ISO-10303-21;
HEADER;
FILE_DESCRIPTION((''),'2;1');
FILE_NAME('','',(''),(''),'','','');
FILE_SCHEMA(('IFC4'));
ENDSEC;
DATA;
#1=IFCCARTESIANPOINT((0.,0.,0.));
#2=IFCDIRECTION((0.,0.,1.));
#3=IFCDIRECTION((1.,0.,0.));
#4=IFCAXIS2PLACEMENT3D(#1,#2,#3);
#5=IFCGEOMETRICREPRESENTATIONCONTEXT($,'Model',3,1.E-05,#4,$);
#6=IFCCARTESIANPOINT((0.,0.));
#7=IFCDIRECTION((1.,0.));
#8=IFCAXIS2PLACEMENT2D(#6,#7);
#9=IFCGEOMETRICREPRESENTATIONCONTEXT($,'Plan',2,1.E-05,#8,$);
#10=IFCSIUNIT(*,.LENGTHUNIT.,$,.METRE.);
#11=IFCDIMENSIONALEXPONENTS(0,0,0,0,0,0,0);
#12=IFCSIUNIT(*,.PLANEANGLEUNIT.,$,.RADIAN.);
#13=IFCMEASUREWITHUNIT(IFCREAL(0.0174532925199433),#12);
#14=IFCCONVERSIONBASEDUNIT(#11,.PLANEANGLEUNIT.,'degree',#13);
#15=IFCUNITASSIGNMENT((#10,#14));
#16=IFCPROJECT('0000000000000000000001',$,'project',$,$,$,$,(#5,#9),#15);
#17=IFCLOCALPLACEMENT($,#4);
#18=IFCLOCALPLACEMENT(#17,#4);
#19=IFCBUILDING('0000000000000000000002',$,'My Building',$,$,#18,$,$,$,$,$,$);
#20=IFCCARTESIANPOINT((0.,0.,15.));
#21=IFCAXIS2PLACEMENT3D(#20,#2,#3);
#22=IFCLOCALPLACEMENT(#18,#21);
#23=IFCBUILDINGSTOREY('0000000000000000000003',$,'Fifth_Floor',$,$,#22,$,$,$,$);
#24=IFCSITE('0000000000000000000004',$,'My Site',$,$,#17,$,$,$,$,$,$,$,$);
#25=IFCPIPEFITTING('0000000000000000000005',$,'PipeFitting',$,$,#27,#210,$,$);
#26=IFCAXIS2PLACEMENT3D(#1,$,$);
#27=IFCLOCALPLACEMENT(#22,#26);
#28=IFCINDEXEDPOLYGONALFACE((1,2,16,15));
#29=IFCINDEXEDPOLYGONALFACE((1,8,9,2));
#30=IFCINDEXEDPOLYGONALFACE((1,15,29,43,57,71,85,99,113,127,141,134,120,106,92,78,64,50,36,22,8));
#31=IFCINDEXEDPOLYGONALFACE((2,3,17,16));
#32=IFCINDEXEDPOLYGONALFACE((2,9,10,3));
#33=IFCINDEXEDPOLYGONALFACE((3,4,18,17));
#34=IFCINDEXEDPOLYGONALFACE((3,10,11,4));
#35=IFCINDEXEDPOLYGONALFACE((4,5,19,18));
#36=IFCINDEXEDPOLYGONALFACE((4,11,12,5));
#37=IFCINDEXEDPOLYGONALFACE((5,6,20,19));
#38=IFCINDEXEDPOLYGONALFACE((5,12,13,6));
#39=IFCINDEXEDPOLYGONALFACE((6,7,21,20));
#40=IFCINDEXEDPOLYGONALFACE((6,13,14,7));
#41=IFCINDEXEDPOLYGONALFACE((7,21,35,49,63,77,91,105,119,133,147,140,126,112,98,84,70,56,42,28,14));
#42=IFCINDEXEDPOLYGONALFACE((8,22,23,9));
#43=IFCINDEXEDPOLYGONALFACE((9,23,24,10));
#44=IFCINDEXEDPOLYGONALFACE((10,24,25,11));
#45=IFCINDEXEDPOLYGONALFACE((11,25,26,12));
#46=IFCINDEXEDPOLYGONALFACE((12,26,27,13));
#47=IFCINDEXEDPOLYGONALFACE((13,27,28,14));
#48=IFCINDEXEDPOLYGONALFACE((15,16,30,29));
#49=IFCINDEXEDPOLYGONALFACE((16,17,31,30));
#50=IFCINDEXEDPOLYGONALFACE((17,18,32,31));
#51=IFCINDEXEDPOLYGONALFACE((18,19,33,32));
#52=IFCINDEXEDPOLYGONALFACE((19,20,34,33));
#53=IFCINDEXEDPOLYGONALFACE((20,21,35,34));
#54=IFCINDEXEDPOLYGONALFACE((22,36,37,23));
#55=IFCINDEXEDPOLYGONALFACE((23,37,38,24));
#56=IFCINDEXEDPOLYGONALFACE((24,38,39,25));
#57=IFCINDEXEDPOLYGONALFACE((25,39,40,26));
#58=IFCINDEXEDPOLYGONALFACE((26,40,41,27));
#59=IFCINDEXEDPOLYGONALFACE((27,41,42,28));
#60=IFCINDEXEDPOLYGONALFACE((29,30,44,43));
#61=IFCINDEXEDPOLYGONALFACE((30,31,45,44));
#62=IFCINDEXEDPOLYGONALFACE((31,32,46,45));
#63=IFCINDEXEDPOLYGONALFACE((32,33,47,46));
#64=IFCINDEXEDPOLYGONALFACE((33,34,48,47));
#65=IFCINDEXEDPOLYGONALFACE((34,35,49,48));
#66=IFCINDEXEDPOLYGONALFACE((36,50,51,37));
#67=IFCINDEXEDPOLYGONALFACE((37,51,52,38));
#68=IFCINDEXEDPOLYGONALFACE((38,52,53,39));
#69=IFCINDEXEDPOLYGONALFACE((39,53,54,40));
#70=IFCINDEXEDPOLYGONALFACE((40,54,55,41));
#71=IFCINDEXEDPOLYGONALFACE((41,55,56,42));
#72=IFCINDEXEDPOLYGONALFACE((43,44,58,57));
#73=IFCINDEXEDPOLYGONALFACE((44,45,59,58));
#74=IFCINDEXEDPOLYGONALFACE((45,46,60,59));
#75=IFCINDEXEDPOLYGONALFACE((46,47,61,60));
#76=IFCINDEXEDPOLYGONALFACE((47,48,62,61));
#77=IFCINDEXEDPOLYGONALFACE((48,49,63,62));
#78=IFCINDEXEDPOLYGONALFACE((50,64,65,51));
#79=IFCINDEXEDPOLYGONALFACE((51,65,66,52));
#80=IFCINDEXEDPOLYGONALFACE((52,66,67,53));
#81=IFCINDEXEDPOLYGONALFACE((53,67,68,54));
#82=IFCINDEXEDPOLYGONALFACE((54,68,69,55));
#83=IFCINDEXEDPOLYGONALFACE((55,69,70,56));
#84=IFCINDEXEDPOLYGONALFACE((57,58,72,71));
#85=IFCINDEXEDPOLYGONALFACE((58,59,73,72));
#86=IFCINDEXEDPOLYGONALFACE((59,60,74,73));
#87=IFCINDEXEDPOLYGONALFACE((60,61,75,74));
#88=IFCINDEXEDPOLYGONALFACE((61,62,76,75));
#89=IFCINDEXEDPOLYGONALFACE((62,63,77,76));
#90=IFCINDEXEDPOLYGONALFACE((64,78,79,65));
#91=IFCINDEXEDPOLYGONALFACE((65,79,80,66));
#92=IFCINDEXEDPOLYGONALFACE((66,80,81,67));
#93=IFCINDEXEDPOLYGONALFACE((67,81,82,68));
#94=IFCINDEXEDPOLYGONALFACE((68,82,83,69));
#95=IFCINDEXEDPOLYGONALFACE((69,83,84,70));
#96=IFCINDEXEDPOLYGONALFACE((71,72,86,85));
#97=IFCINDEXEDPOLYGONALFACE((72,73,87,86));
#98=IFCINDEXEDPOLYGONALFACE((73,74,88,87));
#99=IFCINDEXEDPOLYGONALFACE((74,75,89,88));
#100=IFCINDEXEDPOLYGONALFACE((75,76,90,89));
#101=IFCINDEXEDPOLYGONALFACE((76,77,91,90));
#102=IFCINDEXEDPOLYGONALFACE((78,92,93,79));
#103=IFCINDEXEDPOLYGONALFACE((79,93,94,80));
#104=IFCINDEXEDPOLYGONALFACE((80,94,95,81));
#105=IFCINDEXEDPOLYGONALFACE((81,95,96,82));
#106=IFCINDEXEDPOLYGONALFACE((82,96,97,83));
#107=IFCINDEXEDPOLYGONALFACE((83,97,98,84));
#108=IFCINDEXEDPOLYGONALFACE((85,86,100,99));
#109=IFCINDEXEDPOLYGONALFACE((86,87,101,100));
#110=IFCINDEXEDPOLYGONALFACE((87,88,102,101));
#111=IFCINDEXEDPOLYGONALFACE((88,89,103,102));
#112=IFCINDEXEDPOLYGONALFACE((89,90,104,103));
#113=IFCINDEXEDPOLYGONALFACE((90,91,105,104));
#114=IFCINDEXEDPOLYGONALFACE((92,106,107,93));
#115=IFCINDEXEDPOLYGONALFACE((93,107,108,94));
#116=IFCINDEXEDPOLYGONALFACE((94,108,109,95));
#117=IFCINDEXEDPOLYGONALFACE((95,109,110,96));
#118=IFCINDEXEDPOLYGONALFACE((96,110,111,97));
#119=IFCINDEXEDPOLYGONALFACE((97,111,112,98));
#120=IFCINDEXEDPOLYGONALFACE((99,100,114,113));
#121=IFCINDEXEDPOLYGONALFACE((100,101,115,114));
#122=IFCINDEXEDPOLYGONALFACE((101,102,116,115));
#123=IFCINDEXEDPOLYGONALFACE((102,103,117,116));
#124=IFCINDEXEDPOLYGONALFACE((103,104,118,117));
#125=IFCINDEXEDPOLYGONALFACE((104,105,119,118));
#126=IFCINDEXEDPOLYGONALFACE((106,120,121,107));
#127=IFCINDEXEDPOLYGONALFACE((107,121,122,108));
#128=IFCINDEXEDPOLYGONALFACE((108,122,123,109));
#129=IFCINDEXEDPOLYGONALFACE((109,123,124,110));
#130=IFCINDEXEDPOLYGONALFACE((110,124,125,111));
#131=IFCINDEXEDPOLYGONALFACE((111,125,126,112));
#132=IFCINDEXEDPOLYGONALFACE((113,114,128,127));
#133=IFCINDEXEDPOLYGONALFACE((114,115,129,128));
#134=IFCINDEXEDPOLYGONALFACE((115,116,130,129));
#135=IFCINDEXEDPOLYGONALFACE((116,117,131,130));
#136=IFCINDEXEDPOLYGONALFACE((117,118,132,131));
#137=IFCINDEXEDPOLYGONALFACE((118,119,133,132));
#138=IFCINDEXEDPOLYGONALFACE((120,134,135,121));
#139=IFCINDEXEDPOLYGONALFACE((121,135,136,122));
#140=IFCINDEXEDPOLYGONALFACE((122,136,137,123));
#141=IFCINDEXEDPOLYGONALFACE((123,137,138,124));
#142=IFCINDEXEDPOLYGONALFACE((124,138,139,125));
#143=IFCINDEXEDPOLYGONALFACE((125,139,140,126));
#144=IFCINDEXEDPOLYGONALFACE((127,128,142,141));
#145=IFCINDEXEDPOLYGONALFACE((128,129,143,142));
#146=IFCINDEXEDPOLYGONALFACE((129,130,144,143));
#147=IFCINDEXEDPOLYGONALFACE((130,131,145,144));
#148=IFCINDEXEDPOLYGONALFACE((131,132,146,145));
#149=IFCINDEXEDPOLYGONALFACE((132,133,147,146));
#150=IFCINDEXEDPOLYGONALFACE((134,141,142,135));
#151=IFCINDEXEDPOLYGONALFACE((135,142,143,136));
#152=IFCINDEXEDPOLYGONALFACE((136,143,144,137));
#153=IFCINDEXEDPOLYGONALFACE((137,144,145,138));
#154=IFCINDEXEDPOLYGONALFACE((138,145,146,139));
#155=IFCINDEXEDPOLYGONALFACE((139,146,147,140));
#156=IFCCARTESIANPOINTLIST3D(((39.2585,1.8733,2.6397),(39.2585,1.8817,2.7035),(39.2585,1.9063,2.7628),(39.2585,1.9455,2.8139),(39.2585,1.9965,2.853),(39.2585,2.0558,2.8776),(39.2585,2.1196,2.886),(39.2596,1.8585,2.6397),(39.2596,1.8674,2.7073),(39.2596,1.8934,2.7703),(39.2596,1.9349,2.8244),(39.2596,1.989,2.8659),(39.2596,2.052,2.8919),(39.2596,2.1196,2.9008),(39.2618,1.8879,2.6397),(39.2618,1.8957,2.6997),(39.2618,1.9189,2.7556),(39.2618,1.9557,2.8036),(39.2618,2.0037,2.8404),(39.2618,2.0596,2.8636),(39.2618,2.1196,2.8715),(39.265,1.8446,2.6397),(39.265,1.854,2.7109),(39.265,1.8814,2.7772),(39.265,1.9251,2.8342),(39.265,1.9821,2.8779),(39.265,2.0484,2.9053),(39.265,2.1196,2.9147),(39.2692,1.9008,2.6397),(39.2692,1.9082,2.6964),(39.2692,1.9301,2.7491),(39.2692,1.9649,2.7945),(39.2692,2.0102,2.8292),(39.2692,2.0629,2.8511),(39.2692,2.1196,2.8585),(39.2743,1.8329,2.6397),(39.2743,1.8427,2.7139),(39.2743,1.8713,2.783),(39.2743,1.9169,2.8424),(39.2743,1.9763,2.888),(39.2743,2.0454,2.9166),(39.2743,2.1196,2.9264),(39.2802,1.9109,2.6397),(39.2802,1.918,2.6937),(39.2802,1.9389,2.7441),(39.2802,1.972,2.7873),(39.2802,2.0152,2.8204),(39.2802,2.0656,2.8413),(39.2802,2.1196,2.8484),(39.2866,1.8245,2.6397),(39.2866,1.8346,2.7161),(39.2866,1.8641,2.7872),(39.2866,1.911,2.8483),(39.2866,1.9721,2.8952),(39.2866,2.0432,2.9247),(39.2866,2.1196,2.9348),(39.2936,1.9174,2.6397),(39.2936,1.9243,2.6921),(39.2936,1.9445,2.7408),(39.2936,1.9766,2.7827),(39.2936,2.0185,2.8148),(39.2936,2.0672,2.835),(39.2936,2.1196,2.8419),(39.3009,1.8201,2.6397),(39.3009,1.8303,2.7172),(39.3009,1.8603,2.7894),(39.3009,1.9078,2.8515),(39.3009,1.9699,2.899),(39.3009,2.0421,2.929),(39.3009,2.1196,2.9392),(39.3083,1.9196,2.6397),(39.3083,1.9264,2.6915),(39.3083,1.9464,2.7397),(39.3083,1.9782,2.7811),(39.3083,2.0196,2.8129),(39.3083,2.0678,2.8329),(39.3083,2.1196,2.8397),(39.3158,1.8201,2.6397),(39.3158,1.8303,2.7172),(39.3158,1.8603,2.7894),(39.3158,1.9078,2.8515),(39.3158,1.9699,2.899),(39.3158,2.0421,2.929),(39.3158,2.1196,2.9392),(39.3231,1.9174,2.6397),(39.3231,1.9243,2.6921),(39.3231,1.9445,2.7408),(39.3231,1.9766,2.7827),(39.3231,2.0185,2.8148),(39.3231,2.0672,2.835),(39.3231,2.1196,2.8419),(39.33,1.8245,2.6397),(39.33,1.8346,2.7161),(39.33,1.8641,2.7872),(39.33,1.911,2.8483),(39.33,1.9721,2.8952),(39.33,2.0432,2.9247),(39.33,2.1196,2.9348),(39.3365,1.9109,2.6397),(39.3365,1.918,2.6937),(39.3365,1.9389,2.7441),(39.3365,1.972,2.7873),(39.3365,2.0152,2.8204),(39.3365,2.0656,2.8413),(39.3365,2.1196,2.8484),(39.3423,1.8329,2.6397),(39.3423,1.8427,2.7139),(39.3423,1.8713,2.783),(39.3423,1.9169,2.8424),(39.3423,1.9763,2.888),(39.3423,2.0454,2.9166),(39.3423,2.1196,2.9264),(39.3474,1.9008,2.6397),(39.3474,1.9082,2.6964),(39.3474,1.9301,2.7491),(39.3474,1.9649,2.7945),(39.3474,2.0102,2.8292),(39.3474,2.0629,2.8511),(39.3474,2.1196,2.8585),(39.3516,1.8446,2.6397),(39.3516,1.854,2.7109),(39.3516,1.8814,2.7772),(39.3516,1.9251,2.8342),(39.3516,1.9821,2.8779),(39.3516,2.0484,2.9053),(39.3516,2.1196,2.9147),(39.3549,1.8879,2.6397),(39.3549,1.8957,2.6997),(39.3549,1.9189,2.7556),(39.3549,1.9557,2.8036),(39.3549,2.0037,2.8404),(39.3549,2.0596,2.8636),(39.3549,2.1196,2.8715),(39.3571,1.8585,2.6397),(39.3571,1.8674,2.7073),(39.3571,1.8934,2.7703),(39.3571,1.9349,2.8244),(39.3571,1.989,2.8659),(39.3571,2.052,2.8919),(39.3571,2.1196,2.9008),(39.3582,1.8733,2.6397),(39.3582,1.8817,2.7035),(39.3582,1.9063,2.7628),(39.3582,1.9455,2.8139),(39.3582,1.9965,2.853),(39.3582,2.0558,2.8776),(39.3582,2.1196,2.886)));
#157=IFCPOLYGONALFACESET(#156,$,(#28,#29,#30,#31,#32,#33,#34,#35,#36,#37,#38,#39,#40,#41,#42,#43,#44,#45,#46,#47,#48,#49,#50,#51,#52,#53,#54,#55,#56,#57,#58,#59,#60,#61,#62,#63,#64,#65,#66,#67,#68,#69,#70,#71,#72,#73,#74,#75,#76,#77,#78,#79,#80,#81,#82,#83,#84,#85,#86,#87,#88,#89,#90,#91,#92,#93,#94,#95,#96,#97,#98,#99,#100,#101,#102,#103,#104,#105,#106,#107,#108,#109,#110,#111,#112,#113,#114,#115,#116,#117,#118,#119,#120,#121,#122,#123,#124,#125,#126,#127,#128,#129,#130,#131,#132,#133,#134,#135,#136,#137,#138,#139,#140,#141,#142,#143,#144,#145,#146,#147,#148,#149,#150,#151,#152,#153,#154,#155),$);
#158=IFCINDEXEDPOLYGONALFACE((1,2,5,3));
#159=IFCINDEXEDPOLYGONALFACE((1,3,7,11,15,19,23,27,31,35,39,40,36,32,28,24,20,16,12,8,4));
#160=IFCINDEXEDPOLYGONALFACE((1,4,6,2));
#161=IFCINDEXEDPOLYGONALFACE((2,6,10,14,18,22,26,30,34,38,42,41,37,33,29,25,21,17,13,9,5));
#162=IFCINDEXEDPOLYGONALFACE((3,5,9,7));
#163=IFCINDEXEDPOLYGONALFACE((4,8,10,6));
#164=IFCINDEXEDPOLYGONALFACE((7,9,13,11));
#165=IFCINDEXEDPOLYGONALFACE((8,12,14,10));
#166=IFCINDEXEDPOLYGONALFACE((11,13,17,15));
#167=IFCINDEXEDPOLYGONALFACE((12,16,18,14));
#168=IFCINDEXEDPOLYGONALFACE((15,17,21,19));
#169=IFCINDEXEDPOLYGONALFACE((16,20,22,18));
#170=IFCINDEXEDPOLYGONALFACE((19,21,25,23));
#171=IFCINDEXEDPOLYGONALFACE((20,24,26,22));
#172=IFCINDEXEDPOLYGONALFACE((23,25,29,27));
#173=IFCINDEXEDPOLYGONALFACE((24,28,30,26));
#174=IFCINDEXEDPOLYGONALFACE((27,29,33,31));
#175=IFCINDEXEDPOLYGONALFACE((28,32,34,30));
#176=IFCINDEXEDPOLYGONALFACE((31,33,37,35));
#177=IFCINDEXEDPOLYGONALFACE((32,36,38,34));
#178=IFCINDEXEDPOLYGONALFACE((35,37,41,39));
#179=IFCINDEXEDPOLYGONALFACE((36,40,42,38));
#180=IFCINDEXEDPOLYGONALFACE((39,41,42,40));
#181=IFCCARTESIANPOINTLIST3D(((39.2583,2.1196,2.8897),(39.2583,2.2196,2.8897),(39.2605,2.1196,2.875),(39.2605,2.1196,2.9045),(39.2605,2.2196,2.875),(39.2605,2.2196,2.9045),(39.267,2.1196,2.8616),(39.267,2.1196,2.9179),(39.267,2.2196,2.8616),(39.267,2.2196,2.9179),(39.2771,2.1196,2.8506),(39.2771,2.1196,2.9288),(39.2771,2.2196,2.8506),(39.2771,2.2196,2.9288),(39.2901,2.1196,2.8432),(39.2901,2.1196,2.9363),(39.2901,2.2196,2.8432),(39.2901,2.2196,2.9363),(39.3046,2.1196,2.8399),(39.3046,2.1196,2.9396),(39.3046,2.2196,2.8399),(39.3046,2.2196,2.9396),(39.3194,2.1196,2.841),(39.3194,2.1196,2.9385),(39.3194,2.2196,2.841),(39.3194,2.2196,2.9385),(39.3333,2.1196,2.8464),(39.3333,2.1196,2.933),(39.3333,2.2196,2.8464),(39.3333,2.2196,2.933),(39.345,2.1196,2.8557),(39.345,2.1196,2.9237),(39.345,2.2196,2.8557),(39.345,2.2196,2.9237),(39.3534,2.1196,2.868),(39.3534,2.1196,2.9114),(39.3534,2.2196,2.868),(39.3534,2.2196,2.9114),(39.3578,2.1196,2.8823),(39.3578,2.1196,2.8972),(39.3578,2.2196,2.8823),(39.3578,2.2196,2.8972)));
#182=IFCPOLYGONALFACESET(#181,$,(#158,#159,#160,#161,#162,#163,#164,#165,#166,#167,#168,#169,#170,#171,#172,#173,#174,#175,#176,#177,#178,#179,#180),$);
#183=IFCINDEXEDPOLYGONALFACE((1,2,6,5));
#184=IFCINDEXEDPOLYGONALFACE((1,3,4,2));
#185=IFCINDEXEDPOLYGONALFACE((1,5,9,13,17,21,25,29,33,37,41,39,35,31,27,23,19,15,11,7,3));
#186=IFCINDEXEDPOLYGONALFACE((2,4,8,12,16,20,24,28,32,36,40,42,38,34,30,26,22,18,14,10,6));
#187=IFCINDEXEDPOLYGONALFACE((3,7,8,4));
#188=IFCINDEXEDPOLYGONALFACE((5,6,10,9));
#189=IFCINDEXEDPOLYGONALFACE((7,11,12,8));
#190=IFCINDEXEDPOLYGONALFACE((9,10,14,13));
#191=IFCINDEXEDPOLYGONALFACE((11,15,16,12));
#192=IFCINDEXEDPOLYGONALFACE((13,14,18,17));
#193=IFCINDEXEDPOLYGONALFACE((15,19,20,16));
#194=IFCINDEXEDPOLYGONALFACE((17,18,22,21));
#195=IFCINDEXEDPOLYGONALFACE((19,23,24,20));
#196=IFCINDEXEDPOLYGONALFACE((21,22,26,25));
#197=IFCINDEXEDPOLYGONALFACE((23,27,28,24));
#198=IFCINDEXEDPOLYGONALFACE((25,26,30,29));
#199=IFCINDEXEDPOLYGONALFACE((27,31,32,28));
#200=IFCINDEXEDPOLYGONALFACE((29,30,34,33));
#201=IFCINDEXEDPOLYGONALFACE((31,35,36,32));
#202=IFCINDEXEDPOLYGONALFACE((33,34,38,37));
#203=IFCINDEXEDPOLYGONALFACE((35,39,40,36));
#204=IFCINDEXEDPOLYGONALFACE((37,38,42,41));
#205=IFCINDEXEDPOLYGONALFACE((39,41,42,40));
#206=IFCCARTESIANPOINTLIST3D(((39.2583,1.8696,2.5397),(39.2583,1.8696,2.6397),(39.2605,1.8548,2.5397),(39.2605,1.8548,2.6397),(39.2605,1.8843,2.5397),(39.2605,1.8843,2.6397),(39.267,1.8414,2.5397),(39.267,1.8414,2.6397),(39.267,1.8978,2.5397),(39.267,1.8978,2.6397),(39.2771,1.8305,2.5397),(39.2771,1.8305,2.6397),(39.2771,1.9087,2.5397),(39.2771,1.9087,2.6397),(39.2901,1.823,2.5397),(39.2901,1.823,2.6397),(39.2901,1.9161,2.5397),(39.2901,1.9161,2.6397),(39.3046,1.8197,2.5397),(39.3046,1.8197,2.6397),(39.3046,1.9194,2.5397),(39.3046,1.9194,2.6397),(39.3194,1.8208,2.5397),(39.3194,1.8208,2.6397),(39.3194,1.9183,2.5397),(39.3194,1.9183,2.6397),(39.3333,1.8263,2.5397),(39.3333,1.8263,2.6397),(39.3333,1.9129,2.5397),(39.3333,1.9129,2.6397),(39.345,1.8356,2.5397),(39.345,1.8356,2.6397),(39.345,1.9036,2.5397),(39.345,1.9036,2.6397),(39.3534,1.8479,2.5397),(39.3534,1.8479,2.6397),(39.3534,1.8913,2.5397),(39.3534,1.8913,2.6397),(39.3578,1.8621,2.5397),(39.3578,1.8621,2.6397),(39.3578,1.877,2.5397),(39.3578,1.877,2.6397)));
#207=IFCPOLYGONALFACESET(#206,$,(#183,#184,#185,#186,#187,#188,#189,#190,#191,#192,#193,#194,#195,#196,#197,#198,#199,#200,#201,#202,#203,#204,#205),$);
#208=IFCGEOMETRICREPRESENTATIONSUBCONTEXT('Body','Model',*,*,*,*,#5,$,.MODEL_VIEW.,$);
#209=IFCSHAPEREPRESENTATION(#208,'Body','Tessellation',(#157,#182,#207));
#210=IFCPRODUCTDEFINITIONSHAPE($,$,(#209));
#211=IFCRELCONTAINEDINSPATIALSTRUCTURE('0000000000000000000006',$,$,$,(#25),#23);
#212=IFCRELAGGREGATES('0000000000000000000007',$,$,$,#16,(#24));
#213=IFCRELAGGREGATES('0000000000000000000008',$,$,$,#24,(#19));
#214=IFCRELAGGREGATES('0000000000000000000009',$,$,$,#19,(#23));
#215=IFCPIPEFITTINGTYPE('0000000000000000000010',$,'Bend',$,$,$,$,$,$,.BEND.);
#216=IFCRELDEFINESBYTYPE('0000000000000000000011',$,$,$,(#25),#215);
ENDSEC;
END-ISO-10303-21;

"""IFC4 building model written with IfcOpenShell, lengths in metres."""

from ifc_helpers import new_model, entity, si_unit, converted_unit, frame, origin_with_axes, origin_2d_with_axis, place, context, subcontext, project, spatial, circle, extrude, source, transform, mapped, type_object, type_shapes, element, save


model = new_model("IFC4")

# Units and contexts
model_context = context("Model", 3, precision=1e-05, world=origin_with_axes())
plan_context = context("Plan", 2, precision=1e-05, world=origin_2d_with_axis())
body_context_1 = subcontext(model_context, "Body", "Model", "MODEL_VIEW")
ifc_project = project(units=[si_unit("LENGTHUNIT", "METRE"), converted_unit("PLANEANGLEUNIT", "degree", entity("IfcReal", 0.0174532925199433), si_unit("PLANEANGLEUNIT", "RADIAN"), dimensions=[0, 0, 0, 0, 0, 0, 0])], contexts=[model_context, plan_context])

# Site, building, storey
site_placement = place(None, origin_with_axes())
site = spatial("IfcSite", under=ifc_project, at=site_placement, Name="My Site")
building_placement = place(site_placement, origin_with_axes())
building = spatial("IfcBuilding", under=site, at=building_placement, Name="My Building")
storey_placement = place(building_placement, frame((0.0, 0.0, 15.0), z_axis=(0.0, 0.0, 1.0), x_axis=(1.0, 0.0, 0.0)))
storey = spatial("IfcBuildingStorey", under=building, at=storey_placement, Name="Fifth_Floor")

# Pipe fitting
pipe_fitting_type = type_object("IfcPipeFittingType", Name="Bend", PredefinedType="BEND")
shared_shape_1 = source(origin_with_axes(), body_context_1, "Body", "SolidModel", [
    entity("IfcSweptDiskSolid", entity("IfcIndexedPolyCurve", entity("IfcCartesianPointList3D", [[0.0, 0.0, -0.1], [0.0, -0.0732, -0.2768], [0.0, -0.25, -0.35]]), [entity("IfcArcIndex", [1, 2, 3])]), 0.05),
    extrude(circle(Radius=0.05), origin_with_axes(), (0.0, 0.0, -1.0), 0.1),
    extrude(circle(Radius=0.05), frame((0.0, -0.25, -0.35), z_axis=(0.0, -1.0, 0.0), x_axis=(1.0, 0.0, 0.0)), (0.0, 0.0, 1.0), 0.1),
])
type_shapes(pipe_fitting_type, [shared_shape_1])
for number, where, z_axis, x_axis, name in (
    (1, (39.3083, 2.2196, 2.8897), (0.0, 1.0, 0.0), (-1.0, 0.0, 0.0), "PipeFitting"),
):
    element("IfcPipeFitting", number, at=place(storey_placement, frame(where, z_axis=z_axis, x_axis=x_axis)), inside=storey, type_object=pipe_fitting_type, Name=name, context=body_context_1, shape_type="MappedRepresentation", body=[
        mapped(shared_shape_1, transform((0.0, 0.0, 0.0), x_axis=(1.0, 0.0, 0.0), y_axis=(0.0, 1.0, 0.0), z_axis=(0.0, 0.0, 1.0), scale=1.0)),
    ])

save(model, "model.ifc")
